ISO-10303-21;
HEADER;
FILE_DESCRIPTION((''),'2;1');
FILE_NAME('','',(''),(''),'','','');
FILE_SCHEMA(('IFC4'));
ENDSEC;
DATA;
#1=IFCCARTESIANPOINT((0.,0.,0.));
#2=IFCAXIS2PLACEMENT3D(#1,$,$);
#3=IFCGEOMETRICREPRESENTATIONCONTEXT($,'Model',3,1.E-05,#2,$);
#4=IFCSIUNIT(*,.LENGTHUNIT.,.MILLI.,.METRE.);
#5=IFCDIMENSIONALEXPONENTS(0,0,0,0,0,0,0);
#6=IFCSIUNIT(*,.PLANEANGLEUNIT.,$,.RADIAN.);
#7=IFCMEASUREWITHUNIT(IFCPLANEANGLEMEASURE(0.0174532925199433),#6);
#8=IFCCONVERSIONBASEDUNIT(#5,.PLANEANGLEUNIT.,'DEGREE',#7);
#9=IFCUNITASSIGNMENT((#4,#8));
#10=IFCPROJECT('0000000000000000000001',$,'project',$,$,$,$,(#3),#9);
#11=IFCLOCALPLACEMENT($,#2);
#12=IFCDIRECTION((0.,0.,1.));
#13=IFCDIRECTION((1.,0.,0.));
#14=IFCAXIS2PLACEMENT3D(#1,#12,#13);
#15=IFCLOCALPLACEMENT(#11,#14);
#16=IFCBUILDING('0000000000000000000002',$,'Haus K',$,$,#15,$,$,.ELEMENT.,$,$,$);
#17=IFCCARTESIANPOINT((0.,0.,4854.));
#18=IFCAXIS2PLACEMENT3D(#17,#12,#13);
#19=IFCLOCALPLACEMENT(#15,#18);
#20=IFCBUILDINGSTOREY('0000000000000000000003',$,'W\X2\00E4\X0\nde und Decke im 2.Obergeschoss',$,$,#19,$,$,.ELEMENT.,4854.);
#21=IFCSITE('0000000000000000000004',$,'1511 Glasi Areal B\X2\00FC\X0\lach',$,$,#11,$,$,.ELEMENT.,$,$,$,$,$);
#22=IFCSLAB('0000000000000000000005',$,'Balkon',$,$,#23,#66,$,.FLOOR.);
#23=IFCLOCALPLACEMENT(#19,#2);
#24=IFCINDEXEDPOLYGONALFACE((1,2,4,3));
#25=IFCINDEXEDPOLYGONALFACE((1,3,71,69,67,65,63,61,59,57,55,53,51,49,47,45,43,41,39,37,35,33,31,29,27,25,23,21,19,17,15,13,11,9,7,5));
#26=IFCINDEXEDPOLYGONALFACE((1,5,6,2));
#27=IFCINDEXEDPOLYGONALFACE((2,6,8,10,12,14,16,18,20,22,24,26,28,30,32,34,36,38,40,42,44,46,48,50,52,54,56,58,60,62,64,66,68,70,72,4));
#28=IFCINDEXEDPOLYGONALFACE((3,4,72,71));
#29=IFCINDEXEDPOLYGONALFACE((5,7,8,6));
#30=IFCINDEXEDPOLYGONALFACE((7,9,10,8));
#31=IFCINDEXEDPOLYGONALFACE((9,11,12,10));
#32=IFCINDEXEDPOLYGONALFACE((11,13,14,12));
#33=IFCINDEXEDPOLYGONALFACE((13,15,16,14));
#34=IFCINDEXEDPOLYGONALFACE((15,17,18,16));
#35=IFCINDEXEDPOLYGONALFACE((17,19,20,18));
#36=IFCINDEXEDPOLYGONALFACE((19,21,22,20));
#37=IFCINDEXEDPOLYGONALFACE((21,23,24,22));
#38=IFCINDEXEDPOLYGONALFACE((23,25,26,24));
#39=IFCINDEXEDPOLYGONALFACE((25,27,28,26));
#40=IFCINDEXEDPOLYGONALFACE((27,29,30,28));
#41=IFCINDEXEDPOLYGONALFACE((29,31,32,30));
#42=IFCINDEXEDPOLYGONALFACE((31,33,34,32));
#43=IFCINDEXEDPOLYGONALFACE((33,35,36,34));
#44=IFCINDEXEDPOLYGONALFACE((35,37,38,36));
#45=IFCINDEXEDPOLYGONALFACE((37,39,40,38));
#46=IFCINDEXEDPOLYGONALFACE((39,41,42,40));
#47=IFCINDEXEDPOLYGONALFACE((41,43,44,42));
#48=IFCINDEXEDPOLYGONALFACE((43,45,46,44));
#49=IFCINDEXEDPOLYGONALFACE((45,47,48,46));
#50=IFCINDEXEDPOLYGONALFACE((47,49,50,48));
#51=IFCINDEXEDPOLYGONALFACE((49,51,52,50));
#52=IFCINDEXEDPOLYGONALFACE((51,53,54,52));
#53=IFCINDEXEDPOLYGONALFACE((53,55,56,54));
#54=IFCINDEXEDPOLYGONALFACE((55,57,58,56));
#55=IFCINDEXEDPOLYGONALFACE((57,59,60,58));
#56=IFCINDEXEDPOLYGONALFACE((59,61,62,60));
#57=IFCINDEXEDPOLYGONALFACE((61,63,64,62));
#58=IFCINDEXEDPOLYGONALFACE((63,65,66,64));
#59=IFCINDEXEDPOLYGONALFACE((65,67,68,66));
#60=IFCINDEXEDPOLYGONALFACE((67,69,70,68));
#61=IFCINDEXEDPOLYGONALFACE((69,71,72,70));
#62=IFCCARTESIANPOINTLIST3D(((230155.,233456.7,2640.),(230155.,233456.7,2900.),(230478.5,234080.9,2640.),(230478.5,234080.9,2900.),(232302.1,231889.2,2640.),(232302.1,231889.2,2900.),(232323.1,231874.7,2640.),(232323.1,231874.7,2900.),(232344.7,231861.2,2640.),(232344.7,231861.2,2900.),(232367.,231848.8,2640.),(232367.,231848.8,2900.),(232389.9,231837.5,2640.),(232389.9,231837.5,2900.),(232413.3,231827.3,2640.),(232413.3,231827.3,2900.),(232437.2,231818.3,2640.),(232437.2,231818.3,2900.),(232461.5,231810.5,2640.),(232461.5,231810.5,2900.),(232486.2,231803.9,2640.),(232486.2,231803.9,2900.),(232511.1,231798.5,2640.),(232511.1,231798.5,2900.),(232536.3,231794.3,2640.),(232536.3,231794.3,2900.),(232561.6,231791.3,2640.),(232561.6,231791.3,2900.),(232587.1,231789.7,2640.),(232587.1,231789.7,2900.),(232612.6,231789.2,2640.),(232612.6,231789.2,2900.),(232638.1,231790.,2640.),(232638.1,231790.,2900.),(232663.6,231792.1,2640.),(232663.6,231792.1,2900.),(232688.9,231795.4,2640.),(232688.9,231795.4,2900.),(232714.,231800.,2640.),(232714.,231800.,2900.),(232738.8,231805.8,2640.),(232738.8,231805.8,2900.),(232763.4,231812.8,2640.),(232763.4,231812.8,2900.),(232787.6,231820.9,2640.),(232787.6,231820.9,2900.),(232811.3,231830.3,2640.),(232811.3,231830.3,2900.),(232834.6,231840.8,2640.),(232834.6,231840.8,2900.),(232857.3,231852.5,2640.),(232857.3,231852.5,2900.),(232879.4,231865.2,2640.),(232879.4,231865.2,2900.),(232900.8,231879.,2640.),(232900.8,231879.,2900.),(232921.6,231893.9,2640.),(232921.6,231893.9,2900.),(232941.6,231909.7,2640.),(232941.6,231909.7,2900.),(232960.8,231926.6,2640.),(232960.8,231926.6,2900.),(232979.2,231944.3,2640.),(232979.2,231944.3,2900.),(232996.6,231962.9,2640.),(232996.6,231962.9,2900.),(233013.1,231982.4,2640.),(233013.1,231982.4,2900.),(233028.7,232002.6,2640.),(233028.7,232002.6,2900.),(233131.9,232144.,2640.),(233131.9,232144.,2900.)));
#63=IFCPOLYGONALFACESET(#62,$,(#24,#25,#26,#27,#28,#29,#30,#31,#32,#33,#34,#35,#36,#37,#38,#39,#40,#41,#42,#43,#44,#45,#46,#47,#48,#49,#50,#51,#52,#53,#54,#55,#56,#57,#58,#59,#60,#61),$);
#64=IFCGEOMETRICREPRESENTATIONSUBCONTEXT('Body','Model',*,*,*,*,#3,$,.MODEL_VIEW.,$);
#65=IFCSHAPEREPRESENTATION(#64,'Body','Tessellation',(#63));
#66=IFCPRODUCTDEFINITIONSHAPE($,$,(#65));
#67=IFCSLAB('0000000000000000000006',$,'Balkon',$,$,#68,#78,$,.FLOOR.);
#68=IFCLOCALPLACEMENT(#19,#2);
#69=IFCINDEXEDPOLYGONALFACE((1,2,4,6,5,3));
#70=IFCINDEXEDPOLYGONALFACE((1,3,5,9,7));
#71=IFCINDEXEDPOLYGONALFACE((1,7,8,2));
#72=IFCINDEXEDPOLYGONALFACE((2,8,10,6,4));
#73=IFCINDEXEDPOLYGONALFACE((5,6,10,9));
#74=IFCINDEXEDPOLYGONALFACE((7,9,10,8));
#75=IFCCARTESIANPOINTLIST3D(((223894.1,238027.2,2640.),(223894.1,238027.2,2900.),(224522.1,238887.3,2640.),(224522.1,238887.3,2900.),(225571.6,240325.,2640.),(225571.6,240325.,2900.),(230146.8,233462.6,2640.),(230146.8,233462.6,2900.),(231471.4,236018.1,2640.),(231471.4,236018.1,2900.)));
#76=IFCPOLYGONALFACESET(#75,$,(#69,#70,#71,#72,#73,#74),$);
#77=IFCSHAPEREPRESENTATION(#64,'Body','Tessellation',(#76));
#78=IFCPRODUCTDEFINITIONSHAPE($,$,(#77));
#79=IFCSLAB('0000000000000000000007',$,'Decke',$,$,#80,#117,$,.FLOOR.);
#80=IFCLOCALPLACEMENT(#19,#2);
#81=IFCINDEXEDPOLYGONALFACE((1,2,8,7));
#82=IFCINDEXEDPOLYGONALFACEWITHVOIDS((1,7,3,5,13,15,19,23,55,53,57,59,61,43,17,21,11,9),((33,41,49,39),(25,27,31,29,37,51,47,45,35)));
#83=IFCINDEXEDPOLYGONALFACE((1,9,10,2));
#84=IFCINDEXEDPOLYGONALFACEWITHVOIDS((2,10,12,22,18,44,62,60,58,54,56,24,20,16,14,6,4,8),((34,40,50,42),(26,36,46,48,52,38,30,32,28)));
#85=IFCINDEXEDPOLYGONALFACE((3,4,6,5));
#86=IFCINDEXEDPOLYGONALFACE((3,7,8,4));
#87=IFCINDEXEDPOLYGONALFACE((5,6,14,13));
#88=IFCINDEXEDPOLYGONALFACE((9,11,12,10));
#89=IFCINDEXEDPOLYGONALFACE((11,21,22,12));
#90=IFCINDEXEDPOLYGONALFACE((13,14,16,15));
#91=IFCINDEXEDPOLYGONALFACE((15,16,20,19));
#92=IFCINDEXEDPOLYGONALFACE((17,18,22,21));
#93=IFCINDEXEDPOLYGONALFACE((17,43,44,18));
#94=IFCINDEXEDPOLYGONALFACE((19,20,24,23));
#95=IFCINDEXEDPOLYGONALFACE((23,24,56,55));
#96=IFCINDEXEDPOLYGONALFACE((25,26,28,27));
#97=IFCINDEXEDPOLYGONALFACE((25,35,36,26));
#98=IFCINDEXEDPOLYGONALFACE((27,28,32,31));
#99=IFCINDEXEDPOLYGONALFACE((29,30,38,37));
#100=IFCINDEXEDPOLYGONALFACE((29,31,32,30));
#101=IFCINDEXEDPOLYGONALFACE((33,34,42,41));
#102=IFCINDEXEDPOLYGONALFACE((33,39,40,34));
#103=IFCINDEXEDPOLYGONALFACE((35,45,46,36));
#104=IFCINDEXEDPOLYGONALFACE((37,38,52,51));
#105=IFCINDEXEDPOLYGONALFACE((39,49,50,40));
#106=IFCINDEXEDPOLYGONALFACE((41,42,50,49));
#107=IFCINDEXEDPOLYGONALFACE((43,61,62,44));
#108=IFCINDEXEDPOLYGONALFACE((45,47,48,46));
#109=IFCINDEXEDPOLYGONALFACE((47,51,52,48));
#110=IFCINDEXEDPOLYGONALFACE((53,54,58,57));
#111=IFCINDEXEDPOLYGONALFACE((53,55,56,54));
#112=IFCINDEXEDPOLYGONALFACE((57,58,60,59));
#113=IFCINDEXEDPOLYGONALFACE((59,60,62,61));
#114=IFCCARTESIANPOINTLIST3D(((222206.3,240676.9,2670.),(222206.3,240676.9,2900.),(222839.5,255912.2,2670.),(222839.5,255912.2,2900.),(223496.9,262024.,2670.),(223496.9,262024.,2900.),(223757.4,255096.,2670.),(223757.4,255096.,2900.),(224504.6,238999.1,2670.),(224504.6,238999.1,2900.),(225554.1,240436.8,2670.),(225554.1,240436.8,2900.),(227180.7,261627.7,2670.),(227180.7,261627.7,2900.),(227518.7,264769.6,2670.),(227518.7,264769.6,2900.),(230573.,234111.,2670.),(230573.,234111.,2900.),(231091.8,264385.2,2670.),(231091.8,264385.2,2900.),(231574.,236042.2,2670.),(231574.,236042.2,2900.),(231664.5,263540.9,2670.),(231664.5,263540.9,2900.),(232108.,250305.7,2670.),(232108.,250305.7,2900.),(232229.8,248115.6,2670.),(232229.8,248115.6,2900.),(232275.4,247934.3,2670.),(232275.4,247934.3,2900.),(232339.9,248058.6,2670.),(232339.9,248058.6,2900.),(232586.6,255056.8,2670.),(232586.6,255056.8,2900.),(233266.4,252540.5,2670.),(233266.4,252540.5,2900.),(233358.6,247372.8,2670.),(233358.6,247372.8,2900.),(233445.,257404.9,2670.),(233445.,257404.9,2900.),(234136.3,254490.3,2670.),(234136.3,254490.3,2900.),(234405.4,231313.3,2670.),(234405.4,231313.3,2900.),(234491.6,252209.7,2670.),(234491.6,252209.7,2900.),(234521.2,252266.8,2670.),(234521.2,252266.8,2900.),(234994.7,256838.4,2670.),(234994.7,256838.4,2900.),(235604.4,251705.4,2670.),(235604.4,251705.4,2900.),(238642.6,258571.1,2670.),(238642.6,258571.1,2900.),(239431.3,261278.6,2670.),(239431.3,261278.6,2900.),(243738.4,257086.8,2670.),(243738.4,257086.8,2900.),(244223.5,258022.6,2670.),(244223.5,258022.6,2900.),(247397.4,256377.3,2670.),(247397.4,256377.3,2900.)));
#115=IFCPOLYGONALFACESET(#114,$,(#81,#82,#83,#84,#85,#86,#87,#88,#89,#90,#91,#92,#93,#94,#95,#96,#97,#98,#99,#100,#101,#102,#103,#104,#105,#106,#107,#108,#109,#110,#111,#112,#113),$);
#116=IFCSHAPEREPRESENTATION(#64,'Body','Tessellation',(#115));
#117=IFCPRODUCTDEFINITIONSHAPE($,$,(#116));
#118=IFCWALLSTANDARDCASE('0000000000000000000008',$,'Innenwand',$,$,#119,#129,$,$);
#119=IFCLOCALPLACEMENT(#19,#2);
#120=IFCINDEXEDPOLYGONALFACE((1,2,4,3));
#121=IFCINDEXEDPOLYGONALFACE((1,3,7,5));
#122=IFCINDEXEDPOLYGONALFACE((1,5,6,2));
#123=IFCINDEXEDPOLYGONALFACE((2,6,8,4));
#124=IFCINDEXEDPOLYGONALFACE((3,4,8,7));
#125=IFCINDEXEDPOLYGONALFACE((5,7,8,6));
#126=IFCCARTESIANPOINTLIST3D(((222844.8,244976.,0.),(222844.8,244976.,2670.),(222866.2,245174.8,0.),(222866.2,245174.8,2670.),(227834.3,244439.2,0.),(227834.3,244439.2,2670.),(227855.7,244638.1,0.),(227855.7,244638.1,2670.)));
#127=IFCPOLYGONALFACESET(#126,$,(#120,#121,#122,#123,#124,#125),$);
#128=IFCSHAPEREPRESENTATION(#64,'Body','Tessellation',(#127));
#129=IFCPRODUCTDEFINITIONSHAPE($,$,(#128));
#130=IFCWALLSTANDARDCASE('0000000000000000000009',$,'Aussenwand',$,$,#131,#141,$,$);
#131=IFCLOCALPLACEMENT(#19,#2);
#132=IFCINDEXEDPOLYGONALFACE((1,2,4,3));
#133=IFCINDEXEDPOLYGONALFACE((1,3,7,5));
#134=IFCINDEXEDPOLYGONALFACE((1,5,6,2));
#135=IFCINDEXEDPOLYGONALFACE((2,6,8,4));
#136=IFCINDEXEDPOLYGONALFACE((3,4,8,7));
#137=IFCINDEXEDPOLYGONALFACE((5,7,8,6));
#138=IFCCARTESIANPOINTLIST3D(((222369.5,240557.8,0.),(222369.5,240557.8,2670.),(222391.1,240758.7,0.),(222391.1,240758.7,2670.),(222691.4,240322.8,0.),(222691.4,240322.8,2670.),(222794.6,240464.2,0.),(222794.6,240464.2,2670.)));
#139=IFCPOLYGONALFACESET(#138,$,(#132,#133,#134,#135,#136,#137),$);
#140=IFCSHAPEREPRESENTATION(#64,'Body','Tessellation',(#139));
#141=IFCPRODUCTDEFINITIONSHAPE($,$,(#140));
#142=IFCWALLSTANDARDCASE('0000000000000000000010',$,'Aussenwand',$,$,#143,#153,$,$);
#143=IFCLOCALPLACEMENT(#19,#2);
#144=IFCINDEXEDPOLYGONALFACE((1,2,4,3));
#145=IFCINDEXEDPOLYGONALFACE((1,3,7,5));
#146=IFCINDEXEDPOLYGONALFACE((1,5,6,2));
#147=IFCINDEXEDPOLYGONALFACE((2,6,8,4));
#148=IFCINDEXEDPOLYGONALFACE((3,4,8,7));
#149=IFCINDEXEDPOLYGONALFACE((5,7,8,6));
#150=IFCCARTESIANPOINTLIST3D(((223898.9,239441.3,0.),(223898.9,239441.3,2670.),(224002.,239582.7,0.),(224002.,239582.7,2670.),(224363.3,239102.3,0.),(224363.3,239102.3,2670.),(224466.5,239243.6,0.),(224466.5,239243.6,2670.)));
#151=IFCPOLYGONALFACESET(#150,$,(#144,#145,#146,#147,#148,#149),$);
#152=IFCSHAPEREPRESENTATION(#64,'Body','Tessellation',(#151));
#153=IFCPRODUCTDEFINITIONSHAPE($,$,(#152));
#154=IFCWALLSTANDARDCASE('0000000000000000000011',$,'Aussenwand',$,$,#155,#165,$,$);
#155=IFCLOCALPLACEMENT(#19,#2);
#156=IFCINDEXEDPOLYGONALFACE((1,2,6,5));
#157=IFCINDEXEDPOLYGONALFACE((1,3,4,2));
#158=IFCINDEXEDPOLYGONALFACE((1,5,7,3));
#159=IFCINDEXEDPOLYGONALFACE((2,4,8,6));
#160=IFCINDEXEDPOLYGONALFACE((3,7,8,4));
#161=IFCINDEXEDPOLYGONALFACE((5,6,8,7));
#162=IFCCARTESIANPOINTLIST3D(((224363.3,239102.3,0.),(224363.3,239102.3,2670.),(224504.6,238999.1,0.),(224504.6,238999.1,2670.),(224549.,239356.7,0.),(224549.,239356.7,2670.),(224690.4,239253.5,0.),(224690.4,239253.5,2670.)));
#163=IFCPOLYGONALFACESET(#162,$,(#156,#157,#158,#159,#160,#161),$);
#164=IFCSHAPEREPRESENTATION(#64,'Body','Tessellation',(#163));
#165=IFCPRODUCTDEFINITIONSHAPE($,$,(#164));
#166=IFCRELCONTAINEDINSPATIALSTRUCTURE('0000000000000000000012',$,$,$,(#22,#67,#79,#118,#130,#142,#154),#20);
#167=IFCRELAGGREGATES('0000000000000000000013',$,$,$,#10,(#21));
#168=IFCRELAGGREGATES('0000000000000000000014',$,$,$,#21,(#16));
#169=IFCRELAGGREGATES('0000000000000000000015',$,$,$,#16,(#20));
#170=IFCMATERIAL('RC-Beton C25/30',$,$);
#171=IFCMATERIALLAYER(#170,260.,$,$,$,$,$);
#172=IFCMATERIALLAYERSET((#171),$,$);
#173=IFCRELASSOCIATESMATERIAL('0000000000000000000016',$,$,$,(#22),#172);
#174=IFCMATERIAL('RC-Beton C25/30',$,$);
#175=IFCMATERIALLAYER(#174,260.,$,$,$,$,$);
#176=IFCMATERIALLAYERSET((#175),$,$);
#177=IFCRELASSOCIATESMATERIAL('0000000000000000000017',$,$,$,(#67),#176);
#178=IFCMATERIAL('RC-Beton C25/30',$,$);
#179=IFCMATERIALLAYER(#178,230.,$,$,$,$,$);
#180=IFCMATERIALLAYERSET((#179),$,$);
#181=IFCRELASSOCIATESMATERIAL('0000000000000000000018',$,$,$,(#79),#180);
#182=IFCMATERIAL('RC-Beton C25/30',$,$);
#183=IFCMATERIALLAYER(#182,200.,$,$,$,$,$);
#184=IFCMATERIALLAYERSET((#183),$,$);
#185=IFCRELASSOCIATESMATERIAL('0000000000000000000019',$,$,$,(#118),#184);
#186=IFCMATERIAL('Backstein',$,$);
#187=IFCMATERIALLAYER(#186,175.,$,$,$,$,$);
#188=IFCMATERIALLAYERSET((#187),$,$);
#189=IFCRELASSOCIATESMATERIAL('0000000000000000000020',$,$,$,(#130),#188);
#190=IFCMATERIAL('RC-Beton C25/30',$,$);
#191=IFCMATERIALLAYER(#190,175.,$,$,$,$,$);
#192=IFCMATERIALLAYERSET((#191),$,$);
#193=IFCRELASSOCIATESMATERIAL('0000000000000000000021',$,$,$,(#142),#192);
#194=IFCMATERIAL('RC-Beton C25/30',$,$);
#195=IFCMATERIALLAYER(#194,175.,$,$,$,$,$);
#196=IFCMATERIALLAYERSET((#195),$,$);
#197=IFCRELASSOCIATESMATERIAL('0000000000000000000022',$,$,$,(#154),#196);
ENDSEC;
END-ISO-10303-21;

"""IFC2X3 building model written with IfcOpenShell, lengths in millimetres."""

from ifc_helpers import new_model, entity, si_unit, converted_unit, frame, frame_2d, origin, origin_with_axes, place, context, subcontext, project, spatial, polyline, rectangle, outline, extrude, material, layer, layer_set, layer_usage, element, save


model = new_model("IFC2X3")

# Units and contexts
model_context = context("Model", 3, precision=1e-05, world=origin())
body_context = subcontext(model_context, "Body", "Model", "MODEL_VIEW")
ifc_project = project(units=[si_unit("LENGTHUNIT", "METRE", prefix="MILLI"), converted_unit("PLANEANGLEUNIT", "DEGREE", entity("IfcPlaneAngleMeasure", 0.0174532925199433), si_unit("PLANEANGLEUNIT", "RADIAN"), dimensions=[0, 0, 0, 0, 0, 0, 0])], contexts=[model_context])

# Site, building, storey
site_placement = place(None, origin())
site = spatial("IfcSite", under=ifc_project, at=site_placement, Name="1511 Glasi Areal Bülach", CompositionType="ELEMENT")
building_placement = place(site_placement, origin_with_axes())
building = spatial("IfcBuilding", under=site, at=building_placement, Name="Haus K", CompositionType="ELEMENT")
storey_placement = place(building_placement, frame((0.0, 0.0, 4854.0), z_axis=(0.0, 0.0, 1.0), x_axis=(1.0, 0.0, 0.0)))
storey = spatial("IfcBuildingStorey", under=building, at=storey_placement, Name="Wände und Decke im 2.Obergeschoss", CompositionType="ELEMENT", Elevation=4854.0)

# Slabs
ifc_material_1 = material(Name="RC-Beton C25/30")
ifc_layer_1 = layer(ifc_material_1, 260.0)
ifc_layer_set_1 = layer_set([ifc_layer_1])
ifc_layer_usage_1 = layer_usage(ifc_layer_set_1, "AXIS3", "POSITIVE", 0.0)
slab_1_placement = place(storey_placement, frame((230155.0, 231789.2, 2640.0), z_axis=(0.0, 0.0, 1.0), x_axis=(1.0, 0.0, 0.0)))
element("IfcSlab", 1, at=slab_1_placement, inside=storey, material=ifc_layer_usage_1, Name="Balkon", PredefinedType="FLOOR", context=body_context, shape_type="SweptSolid", body=[
    extrude(outline(polyline([(2147.1, 100.0), (2168.1, 85.5), (2189.8, 72.0), (2212.1, 59.5), (2235.0, 48.2), (2258.4, 38.1), (2282.2, 29.1), (2306.5, 21.3), (2331.2, 14.6), (2356.1, 9.2), (2381.3, 5.1), (2406.7, 2.1), (2432.1, 0.4), (2457.7, 0.0), (2483.2, 0.8), (2508.6, 2.9), (2533.9, 6.2), (2559.0, 10.8), (2583.9, 16.5), (2608.4, 23.5), (2632.6, 31.7), (2656.3, 41.1), (2679.6, 51.6), (2702.3, 63.2), (2724.4, 76.0), (2745.9, 89.8), (2766.6, 104.7), (2786.6, 120.5), (2805.8, 137.3), (2824.2, 155.1), (2841.7, 173.7), (2858.2, 193.1), (2873.7, 213.4), (2976.9, 354.7), (323.6, 2291.7), (0.0, 1667.4), (2147.1, 100.0)])), origin_with_axes(), (0.0, 0.0, 1.0), 260.0),
])
ifc_material_2 = material(Name="RC-Beton C25/30")
ifc_layer_2 = layer(ifc_material_2, 260.0)
ifc_layer_set_2 = layer_set([ifc_layer_2])
ifc_layer_usage_2 = layer_usage(ifc_layer_set_2, "AXIS3", "POSITIVE", 0.0)
slab_2_placement = place(storey_placement, frame((223894.1, 233462.6, 2640.0), z_axis=(0.0, 0.0, 1.0), x_axis=(1.0, 0.0, 0.0)))
element("IfcSlab", 2, at=slab_2_placement, inside=storey, material=ifc_layer_usage_2, Name="Balkon", PredefinedType="FLOOR", context=body_context, shape_type="SweptSolid", body=[
    extrude(outline(polyline([(0.0, 4564.5), (6252.7, 0.0), (7577.3, 2555.4), (1677.5, 6862.4), (627.9, 5424.7), (0.0, 4564.5)])), origin_with_axes(), (0.0, 0.0, 1.0), 260.0),
])

# Slab, openings
ifc_material_3 = material(Name="RC-Beton C25/30")
ifc_layer_3 = layer(ifc_material_3, 230.0)
ifc_layer_set_3 = layer_set([ifc_layer_3])
ifc_layer_usage_3 = layer_usage(ifc_layer_set_3, "AXIS3", "POSITIVE", 0.0)
slab_3_placement = place(storey_placement, frame((222206.3, 231313.3, 2670.0), z_axis=(0.0, 0.0, 1.0), x_axis=(1.0, 0.0, 0.0)))
slab_3 = element("IfcSlab", 3, at=slab_3_placement, inside=storey, material=ifc_layer_usage_3, Name="Decke", PredefinedType="FLOOR", context=body_context, shape_type="SweptSolid", body=[
    extrude(outline(polyline([(22017.2, 26709.3), (21532.1, 25773.5), (16436.3, 27257.8), (17225.0, 29965.3), (9458.2, 32227.6), (8885.5, 33072.0), (5312.4, 33456.3), (4974.4, 30314.5), (1290.7, 30710.7), (633.2, 24598.9), (1551.1, 23782.8), (0.0, 9363.6), (2298.3, 7685.8), (3347.9, 9123.5), (9367.7, 4728.9), (8366.7, 2797.7), (12199.1, 0.0), (25191.1, 25064.1), (22017.2, 26709.3)])), origin_with_axes(), (0.0, 0.0, 1.0), 230.0),
])
opening_1_placement = place(slab_3_placement, frame((9901.7, 16059.5, 0.0), z_axis=(0.0, 0.0, 1.0), x_axis=(1.0, 0.0, 0.0)))
element("IfcOpeningElement", 4, at=opening_1_placement, cuts=slab_3, ObjectType="Opening", context=body_context, shape_type="SweptSolid", body=[
    extrude(outline(polyline([(2383.7, 4836.9), (1158.4, 5167.7), (0.0, 2932.8), (121.8, 742.8), (231.9, 685.7), (167.5, 561.4), (1250.6, 0.0), (3496.4, 4332.5), (2413.3, 4894.0), (2383.7, 4836.9)])), origin_with_axes(), (0.0, 0.0, 1.0), 230.0),
])
opening_2_placement = place(slab_3_placement, frame((11238.7, 26091.6, 0.0), z_axis=(0.0, 0.0, 1.0), x_axis=(1.0, 0.0, 0.0)))
element("IfcOpeningElement", 5, at=opening_2_placement, cuts=slab_3, ObjectType="Opening", context=body_context, shape_type="SweptSolid", body=[
    extrude(rectangle(XDim=2500.0, YDim=1650.0, at=frame_2d((345.7, -1457.3), x_axis=(-0.343332, -0.939214))), origin_with_axes(), (0.0, 0.0, 1.0), 230.0),
])

# Walls
ifc_material_4 = material(Name="RC-Beton C25/30")
ifc_layer_4 = layer(ifc_material_4, 200.0)
ifc_layer_set_4 = layer_set([ifc_layer_4])
ifc_layer_usage_4 = layer_usage(ifc_layer_set_4, "AXIS2", "POSITIVE", 0.0)
wall_1_placement = place(storey_placement, frame((222844.8, 244976.0, 0.0), z_axis=(0.0, 0.0, 1.0), x_axis=(0.994264, -0.106958, 0.0)))
element("IfcWallStandardCase", 6, at=wall_1_placement, inside=storey, material=ifc_layer_usage_4, Name="Innenwand", context=body_context, shape_type="SweptSolid", body=[
    extrude(rectangle(XDim=5018.3, YDim=200.0, at=frame_2d((2509.2, 100.0), x_axis=(1.0, 0.0))), origin_with_axes(), (0.0, 0.0, 1.0), 2670.0),
])
ifc_material_5 = material(Name="Backstein")
ifc_layer_5 = layer(ifc_material_5, 175.0)
ifc_layer_set_5 = layer_set([ifc_layer_5])
ifc_layer_usage_5 = layer_usage(ifc_layer_set_5, "AXIS2", "POSITIVE", 0.0)
wall_2_placement = place(storey_placement, frame((222369.5, 240557.8, 0.0), z_axis=(0.0, 0.0, 1.0), x_axis=(0.807681, -0.589619, 0.0)))
element("IfcWallStandardCase", 7, at=wall_2_placement, inside=storey, material=ifc_layer_usage_5, Name="Aussenwand", context=body_context, shape_type="SweptSolid", body=[
    extrude(outline(polyline([(0.0, 0.0), (398.5, 0.0), (398.5, 175.0), (-101.0, 175.0), (0.0, 0.0)])), origin_with_axes(), (0.0, 0.0, 1.0), 2670.0),
])
ifc_material_6 = material(Name="RC-Beton C25/30")
ifc_layer_6 = layer(ifc_material_6, 175.0)
ifc_layer_set_6 = layer_set([ifc_layer_6])
ifc_layer_usage_6 = layer_usage(ifc_layer_set_6, "AXIS2", "POSITIVE", 0.0)
wall_3_placement = place(storey_placement, frame((223898.9, 239441.3, 0.0), z_axis=(0.0, 0.0, 1.0), x_axis=(0.807681, -0.589619, 0.0)))
element("IfcWallStandardCase", 8, at=wall_3_placement, inside=storey, material=ifc_layer_usage_6, Name="Aussenwand", context=body_context, shape_type="SweptSolid", body=[
    extrude(rectangle(XDim=575.0, YDim=175.0, at=frame_2d((287.5, 87.5), x_axis=(1.0, 0.0))), origin_with_axes(), (0.0, 0.0, 1.0), 2670.0),
])
ifc_material_7 = material(Name="RC-Beton C25/30")
ifc_layer_7 = layer(ifc_material_7, 175.0)
ifc_layer_set_7 = layer_set([ifc_layer_7])
ifc_layer_usage_7 = layer_usage(ifc_layer_set_7, "AXIS2", "POSITIVE", 0.0)
wall_4_placement = place(storey_placement, frame((224504.6, 238999.1, 0.0), z_axis=(0.0, 0.0, 1.0), x_axis=(0.589619, 0.807681, 0.0)))
element("IfcWallStandardCase", 9, at=wall_4_placement, inside=storey, material=ifc_layer_usage_7, Name="Aussenwand", context=body_context, shape_type="SweptSolid", body=[
    extrude(rectangle(XDim=315.0, YDim=175.0, at=frame_2d((157.5, 87.5), x_axis=(1.0, 0.0))), origin_with_axes(), (0.0, 0.0, 1.0), 2670.0),
])

save(model, "model.ifc")
